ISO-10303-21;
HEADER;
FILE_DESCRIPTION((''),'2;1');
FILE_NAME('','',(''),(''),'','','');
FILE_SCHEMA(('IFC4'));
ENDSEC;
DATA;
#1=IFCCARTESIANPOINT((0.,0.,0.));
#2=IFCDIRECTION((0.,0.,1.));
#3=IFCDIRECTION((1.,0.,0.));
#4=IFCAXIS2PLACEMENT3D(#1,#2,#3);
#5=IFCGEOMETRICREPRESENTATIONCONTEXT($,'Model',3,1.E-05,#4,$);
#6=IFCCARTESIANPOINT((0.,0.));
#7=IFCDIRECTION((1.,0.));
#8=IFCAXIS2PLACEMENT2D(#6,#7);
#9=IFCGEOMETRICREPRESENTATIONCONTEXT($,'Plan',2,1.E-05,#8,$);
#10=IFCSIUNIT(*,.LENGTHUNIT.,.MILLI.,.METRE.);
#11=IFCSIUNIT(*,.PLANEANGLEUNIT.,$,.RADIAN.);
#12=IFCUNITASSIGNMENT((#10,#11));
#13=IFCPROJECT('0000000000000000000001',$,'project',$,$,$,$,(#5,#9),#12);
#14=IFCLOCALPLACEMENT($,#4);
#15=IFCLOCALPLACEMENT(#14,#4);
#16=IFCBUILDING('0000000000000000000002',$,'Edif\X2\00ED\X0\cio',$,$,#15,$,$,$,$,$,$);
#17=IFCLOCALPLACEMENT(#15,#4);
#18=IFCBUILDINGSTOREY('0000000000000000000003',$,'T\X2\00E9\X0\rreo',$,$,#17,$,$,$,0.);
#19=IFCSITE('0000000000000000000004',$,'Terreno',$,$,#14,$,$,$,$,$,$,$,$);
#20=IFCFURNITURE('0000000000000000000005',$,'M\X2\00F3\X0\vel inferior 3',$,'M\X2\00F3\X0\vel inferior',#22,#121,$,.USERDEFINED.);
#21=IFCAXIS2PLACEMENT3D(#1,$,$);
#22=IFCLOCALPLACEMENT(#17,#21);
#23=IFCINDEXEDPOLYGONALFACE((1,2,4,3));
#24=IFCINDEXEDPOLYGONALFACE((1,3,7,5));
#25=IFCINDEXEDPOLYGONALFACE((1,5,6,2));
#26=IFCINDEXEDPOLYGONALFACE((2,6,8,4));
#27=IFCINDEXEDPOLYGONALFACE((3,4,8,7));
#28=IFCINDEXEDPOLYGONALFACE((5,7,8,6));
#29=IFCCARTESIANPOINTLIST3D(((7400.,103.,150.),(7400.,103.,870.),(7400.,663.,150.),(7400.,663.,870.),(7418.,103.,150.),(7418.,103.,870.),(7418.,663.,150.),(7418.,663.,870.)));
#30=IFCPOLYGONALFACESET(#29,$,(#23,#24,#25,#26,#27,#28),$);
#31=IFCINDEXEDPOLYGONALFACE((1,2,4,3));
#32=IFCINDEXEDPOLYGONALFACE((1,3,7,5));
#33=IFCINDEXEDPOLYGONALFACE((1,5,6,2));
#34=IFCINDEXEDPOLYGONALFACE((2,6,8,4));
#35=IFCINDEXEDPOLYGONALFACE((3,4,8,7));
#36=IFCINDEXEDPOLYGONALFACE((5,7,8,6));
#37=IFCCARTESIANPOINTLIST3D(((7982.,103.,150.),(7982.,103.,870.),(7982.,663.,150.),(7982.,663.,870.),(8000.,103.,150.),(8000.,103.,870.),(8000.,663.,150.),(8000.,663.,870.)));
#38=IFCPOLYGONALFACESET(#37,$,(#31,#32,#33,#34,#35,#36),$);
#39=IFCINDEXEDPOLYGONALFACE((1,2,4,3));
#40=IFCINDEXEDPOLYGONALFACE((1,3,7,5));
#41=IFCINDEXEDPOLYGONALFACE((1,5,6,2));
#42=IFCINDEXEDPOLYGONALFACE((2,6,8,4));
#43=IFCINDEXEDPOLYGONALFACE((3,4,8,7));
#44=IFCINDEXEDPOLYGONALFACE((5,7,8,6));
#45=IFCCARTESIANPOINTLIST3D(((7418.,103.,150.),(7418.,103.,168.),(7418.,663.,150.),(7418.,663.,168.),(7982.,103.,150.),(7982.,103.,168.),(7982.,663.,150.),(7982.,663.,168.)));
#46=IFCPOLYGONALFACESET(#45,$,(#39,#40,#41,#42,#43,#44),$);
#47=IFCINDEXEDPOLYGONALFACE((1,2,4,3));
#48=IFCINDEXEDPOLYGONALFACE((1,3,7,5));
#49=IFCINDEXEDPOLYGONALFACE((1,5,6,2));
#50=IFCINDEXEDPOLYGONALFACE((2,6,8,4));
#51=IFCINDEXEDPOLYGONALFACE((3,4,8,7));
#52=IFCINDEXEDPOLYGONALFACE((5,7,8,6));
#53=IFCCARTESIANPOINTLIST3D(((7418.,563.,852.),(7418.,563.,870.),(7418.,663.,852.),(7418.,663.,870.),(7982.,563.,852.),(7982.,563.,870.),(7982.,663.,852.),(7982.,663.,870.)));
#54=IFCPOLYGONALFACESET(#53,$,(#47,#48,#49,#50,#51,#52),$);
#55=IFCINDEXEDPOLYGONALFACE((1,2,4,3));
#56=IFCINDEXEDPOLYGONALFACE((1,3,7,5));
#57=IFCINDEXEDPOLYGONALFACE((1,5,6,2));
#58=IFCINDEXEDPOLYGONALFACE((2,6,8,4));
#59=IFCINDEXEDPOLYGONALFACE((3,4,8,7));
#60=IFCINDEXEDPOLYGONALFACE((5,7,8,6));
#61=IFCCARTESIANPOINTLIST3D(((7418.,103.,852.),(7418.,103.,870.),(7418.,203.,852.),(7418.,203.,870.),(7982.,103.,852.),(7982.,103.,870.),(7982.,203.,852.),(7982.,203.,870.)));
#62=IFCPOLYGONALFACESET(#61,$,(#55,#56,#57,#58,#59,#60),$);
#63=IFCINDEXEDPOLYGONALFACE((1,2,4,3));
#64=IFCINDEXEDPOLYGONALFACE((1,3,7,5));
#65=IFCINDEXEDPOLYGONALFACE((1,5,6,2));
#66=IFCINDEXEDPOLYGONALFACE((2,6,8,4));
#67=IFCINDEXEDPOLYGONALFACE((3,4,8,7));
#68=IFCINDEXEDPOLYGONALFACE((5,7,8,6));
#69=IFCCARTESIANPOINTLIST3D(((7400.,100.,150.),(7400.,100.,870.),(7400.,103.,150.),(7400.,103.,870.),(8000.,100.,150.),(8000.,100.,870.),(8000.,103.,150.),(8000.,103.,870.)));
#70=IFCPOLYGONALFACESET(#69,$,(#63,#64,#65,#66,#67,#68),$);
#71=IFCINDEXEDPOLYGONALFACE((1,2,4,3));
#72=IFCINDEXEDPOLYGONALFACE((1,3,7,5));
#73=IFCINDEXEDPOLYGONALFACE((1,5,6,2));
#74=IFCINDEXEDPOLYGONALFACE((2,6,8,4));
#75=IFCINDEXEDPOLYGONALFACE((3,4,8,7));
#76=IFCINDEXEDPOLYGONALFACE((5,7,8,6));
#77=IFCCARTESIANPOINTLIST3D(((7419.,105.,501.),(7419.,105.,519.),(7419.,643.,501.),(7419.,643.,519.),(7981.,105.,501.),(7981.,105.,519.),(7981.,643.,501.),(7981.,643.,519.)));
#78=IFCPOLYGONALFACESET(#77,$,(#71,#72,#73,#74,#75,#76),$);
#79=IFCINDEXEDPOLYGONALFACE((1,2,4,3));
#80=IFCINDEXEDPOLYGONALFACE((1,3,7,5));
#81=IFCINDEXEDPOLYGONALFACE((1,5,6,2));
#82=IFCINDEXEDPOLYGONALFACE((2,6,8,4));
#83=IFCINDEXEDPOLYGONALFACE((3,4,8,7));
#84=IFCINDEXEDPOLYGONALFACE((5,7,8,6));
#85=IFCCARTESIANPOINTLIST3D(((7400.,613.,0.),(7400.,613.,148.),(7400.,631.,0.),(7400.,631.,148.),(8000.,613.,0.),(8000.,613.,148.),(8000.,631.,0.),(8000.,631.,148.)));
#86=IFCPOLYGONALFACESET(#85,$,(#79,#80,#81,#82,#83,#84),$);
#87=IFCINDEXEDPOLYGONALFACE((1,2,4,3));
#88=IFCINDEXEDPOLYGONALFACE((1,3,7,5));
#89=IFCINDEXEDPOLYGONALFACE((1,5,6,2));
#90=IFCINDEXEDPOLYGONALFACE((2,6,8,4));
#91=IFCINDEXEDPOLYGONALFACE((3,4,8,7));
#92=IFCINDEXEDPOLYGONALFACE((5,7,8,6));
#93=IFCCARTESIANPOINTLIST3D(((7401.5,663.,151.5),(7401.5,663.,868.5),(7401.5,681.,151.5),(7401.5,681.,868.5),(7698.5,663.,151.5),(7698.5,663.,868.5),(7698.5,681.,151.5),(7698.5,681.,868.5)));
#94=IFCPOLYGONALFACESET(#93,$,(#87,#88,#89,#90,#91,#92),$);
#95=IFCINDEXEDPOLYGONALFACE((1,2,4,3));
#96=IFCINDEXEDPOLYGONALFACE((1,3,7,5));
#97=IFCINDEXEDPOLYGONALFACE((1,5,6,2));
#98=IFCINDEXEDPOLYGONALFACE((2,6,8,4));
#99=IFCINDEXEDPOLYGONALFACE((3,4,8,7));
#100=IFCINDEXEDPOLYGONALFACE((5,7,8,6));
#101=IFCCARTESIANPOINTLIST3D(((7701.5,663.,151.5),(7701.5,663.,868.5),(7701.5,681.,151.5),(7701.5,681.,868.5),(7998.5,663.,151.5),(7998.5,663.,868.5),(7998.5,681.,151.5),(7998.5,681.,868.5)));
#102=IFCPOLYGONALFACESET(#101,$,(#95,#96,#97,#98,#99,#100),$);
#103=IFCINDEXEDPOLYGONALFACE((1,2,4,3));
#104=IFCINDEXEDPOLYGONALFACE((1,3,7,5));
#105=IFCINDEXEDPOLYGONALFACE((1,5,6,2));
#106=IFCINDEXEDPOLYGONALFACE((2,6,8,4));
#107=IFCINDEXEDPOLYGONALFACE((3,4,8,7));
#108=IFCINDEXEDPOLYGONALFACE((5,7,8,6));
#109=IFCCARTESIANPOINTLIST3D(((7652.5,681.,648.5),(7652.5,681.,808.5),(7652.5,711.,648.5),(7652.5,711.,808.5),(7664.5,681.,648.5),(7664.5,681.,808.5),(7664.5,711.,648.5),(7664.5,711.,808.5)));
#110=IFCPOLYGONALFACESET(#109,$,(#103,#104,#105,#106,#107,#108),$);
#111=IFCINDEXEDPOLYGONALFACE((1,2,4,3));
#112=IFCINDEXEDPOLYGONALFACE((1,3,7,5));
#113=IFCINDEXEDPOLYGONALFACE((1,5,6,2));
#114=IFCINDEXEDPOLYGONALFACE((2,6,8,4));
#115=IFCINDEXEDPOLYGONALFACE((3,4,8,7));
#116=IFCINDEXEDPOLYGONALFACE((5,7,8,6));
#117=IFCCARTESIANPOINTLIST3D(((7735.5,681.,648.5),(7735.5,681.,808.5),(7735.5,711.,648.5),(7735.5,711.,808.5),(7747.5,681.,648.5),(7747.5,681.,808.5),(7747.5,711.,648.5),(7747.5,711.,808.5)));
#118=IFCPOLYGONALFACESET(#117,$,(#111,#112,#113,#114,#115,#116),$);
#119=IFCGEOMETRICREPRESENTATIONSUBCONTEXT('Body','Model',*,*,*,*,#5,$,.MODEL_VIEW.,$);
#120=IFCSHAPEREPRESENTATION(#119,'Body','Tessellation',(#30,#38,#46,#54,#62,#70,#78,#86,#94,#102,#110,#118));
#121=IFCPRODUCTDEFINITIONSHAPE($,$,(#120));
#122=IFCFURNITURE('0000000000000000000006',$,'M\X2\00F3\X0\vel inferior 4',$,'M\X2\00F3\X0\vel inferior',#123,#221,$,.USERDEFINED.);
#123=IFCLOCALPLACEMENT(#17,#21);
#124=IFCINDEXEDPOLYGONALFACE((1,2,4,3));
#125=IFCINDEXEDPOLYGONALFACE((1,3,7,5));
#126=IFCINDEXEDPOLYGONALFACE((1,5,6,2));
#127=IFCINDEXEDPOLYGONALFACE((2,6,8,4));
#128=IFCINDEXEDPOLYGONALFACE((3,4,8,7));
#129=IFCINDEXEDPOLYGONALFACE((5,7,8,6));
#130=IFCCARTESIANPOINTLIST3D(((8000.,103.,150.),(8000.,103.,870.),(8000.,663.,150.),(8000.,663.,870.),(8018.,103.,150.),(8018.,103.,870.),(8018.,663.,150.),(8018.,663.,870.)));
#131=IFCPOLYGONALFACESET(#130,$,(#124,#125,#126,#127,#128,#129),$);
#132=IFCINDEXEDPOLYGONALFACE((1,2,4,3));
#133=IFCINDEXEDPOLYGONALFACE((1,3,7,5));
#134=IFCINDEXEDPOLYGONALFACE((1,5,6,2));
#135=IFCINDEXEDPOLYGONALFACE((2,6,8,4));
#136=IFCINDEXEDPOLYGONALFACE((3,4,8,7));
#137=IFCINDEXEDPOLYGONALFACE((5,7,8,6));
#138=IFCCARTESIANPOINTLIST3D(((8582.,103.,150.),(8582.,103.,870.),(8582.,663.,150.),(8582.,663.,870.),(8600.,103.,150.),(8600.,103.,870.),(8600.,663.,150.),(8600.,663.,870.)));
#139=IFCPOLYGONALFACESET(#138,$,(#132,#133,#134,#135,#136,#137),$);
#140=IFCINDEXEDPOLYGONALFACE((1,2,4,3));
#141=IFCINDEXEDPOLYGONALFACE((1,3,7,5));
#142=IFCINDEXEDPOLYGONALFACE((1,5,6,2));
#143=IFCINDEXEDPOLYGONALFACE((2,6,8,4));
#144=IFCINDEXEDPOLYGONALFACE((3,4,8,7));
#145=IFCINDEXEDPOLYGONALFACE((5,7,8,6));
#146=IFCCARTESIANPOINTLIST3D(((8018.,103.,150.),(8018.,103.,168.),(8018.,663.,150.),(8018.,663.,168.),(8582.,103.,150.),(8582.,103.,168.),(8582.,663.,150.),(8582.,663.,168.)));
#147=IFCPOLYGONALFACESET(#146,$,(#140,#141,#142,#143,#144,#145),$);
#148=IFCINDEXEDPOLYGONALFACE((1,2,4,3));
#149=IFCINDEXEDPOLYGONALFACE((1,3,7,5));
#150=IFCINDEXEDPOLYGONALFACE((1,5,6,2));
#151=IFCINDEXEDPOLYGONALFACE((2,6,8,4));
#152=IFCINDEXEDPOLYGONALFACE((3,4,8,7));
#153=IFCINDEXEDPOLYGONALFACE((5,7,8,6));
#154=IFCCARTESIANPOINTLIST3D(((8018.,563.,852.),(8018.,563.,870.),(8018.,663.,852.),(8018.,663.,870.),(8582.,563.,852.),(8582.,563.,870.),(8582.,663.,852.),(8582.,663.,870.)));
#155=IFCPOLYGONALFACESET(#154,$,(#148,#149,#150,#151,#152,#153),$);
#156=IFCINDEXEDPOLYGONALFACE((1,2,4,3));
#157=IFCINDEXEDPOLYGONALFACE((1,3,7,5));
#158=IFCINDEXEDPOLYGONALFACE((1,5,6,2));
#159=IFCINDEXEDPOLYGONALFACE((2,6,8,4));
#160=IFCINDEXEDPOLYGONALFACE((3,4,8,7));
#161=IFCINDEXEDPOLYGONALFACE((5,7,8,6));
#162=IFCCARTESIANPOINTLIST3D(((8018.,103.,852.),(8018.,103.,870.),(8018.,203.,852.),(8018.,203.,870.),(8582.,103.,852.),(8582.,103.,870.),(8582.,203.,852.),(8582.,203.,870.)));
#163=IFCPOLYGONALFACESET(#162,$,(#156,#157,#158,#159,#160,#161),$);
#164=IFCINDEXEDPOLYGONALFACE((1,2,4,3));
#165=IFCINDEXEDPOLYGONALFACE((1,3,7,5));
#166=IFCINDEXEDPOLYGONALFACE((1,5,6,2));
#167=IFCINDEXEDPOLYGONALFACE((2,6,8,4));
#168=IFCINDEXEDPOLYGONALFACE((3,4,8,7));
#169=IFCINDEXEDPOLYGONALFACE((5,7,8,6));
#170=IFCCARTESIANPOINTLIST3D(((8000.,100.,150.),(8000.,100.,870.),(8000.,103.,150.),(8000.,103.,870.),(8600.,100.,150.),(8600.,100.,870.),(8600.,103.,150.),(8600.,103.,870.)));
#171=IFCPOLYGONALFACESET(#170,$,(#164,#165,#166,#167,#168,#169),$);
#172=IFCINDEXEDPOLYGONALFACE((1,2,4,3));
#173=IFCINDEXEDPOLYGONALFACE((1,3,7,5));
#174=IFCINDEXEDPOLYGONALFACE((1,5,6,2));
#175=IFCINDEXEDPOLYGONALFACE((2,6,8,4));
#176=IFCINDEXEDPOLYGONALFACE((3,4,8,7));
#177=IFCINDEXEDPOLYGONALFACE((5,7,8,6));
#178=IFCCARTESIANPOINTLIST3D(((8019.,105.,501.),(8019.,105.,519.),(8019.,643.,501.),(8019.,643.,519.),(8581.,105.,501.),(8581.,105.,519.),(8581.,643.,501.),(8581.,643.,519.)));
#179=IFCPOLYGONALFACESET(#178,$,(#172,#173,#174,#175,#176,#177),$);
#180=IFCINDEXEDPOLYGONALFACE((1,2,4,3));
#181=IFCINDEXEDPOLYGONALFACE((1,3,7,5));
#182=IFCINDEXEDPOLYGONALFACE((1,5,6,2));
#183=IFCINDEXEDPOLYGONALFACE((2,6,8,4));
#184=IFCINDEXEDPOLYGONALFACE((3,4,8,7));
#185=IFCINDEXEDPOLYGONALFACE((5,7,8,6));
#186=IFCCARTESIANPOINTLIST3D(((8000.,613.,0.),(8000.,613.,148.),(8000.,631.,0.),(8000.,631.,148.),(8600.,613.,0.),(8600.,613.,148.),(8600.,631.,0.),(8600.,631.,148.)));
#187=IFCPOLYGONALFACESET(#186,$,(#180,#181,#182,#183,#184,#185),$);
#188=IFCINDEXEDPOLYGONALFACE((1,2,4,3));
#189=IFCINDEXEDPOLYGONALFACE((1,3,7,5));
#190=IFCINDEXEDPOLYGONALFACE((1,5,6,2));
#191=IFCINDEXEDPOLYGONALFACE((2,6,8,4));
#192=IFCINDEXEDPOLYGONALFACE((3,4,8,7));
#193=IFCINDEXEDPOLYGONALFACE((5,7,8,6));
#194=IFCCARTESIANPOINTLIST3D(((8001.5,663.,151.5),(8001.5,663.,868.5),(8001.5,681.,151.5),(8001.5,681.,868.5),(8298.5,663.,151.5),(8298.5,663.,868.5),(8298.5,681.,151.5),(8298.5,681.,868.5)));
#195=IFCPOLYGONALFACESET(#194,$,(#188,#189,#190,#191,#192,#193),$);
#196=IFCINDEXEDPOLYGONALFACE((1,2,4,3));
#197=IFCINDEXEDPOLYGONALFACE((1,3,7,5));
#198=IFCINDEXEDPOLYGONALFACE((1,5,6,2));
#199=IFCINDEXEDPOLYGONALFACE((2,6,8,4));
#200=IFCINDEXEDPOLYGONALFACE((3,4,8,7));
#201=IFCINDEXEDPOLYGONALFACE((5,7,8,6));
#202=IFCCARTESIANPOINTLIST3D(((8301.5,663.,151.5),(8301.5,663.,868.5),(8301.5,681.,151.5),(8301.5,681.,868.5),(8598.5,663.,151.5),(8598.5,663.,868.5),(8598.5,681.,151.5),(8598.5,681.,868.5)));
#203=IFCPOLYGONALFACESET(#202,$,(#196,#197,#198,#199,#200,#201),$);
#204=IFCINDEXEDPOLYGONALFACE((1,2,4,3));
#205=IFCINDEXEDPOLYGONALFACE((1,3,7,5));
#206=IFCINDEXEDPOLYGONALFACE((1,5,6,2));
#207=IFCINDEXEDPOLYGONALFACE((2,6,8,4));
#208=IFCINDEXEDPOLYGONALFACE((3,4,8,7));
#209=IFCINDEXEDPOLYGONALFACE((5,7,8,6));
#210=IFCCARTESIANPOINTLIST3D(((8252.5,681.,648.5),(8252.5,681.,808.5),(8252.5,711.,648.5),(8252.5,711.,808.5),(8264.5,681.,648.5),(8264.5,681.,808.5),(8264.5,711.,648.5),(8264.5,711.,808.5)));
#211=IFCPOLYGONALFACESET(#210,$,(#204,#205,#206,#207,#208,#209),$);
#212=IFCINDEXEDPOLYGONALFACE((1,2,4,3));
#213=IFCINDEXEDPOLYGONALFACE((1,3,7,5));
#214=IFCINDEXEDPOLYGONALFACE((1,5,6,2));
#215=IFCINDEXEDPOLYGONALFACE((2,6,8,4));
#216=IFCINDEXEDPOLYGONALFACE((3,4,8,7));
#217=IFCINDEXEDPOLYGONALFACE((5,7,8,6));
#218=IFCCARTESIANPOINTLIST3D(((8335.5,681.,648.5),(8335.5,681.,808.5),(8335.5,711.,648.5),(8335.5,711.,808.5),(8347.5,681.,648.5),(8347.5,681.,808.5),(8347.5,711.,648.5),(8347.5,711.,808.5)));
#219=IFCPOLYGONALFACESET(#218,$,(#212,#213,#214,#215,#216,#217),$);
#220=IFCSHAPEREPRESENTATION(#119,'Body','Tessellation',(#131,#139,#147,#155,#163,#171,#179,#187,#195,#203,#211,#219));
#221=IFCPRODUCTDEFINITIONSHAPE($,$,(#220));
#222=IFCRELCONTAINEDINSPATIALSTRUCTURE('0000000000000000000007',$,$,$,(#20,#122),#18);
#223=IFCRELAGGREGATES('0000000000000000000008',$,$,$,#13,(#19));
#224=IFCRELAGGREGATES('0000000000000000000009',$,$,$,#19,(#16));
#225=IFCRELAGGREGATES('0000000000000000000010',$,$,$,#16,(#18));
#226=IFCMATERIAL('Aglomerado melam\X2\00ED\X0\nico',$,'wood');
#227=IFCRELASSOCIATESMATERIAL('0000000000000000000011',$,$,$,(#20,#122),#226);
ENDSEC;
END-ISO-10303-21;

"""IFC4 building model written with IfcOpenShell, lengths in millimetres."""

from ifc_helpers import new_model, si_unit, frame, frame_2d, origin, origin_with_axes, origin_2d_with_axis, place, context, subcontext, project, spatial, rectangle, extrude, material, element, save


model = new_model("IFC4")

# Units and contexts
model_context = context("Model", 3, precision=1e-05, world=origin_with_axes())
plan_context = context("Plan", 2, precision=1e-05, world=origin_2d_with_axis())
body_context = subcontext(model_context, "Body", "Model", "MODEL_VIEW")
ifc_project = project(units=[si_unit("LENGTHUNIT", "METRE", prefix="MILLI"), si_unit("PLANEANGLEUNIT", "RADIAN")], contexts=[model_context, plan_context])

# Site, building, storey
site_placement = place(None, origin_with_axes())
site = spatial("IfcSite", under=ifc_project, at=site_placement, Name="Terreno")
building_placement = place(site_placement, origin_with_axes())
building = spatial("IfcBuilding", under=site, at=building_placement, Name="Edifício")
storey_placement = place(building_placement, origin_with_axes())
storey = spatial("IfcBuildingStorey", under=building, at=storey_placement, Name="Térreo", Elevation=0.0)

# Furniture
ifc_material_1 = material(Name="Aglomerado melamínico", Category="wood")
furniture_1_placement = place(storey_placement, frame((7400.0, 100.0, 0.0), z_axis=(0.0, 0.0, 1.0), x_axis=(1.0, 0.0, 0.0)))
element("IfcFurniture", 1, at=furniture_1_placement, inside=storey, material=ifc_material_1, Name="Móvel inferior 3", ObjectType="Móvel inferior", PredefinedType="USERDEFINED", context=body_context, shape_type="SweptSolid", body=[
    extrude(rectangle(XDim=18.0, YDim=560.0, at=frame_2d((9.0, 283.0))), frame((0.0, 0.0, 150.0)), (0.0, 0.0, 1.0), 720.0),
    extrude(rectangle(XDim=18.0, YDim=560.0, at=frame_2d((591.0, 283.0))), frame((0.0, 0.0, 150.0)), (0.0, 0.0, 1.0), 720.0),
    extrude(rectangle(XDim=564.0, YDim=560.0, at=frame_2d((300.0, 283.0))), frame((0.0, 0.0, 150.0)), (0.0, 0.0, 1.0), 18.0),
    extrude(rectangle(XDim=564.0, YDim=100.0, at=frame_2d((300.0, 513.0))), frame((0.0, 0.0, 852.0)), (0.0, 0.0, 1.0), 18.0),
    extrude(rectangle(XDim=564.0, YDim=100.0, at=frame_2d((300.0, 53.0))), frame((0.0, 0.0, 852.0)), (0.0, 0.0, 1.0), 18.0),
    extrude(rectangle(XDim=600.0, YDim=3.0, at=frame_2d((300.0, 1.5))), frame((0.0, 0.0, 150.0)), (0.0, 0.0, 1.0), 720.0),
    extrude(rectangle(XDim=562.0, YDim=538.0, at=frame_2d((300.0, 274.0))), frame((0.0, 0.0, 501.0)), (0.0, 0.0, 1.0), 18.0),
    extrude(rectangle(XDim=600.0, YDim=18.0, at=frame_2d((300.0, 522.0))), origin(), (0.0, 0.0, 1.0), 148.0),
    extrude(rectangle(XDim=297.0, YDim=18.0, at=frame_2d((150.0, 572.0))), frame((0.0, 0.0, 151.5)), (0.0, 0.0, 1.0), 717.0),
    extrude(rectangle(XDim=297.0, YDim=18.0, at=frame_2d((450.0, 572.0))), frame((0.0, 0.0, 151.5)), (0.0, 0.0, 1.0), 717.0),
    extrude(rectangle(XDim=12.0, YDim=30.0, at=frame_2d((258.5, 596.0))), frame((0.0, 0.0, 648.5)), (0.0, 0.0, 1.0), 160.0),
    extrude(rectangle(XDim=12.0, YDim=30.0, at=frame_2d((341.5, 596.0))), frame((0.0, 0.0, 648.5)), (0.0, 0.0, 1.0), 160.0),
])
furniture_2_placement = place(storey_placement, frame((8000.0, 100.0, 0.0), z_axis=(0.0, 0.0, 1.0), x_axis=(1.0, 0.0, 0.0)))
element("IfcFurniture", 2, at=furniture_2_placement, inside=storey, material=ifc_material_1, Name="Móvel inferior 4", ObjectType="Móvel inferior", PredefinedType="USERDEFINED", context=body_context, shape_type="SweptSolid", body=[
    extrude(rectangle(XDim=18.0, YDim=560.0, at=frame_2d((9.0, 283.0))), frame((0.0, 0.0, 150.0)), (0.0, 0.0, 1.0), 720.0),
    extrude(rectangle(XDim=18.0, YDim=560.0, at=frame_2d((591.0, 283.0))), frame((0.0, 0.0, 150.0)), (0.0, 0.0, 1.0), 720.0),
    extrude(rectangle(XDim=564.0, YDim=560.0, at=frame_2d((300.0, 283.0))), frame((0.0, 0.0, 150.0)), (0.0, 0.0, 1.0), 18.0),
    extrude(rectangle(XDim=564.0, YDim=100.0, at=frame_2d((300.0, 513.0))), frame((0.0, 0.0, 852.0)), (0.0, 0.0, 1.0), 18.0),
    extrude(rectangle(XDim=564.0, YDim=100.0, at=frame_2d((300.0, 53.0))), frame((0.0, 0.0, 852.0)), (0.0, 0.0, 1.0), 18.0),
    extrude(rectangle(XDim=600.0, YDim=3.0, at=frame_2d((300.0, 1.5))), frame((0.0, 0.0, 150.0)), (0.0, 0.0, 1.0), 720.0),
    extrude(rectangle(XDim=562.0, YDim=538.0, at=frame_2d((300.0, 274.0))), frame((0.0, 0.0, 501.0)), (0.0, 0.0, 1.0), 18.0),
    extrude(rectangle(XDim=600.0, YDim=18.0, at=frame_2d((300.0, 522.0))), origin(), (0.0, 0.0, 1.0), 148.0),
    extrude(rectangle(XDim=297.0, YDim=18.0, at=frame_2d((150.0, 572.0))), frame((0.0, 0.0, 151.5)), (0.0, 0.0, 1.0), 717.0),
    extrude(rectangle(XDim=297.0, YDim=18.0, at=frame_2d((450.0, 572.0))), frame((0.0, 0.0, 151.5)), (0.0, 0.0, 1.0), 717.0),
    extrude(rectangle(XDim=12.0, YDim=30.0, at=frame_2d((258.5, 596.0))), frame((0.0, 0.0, 648.5)), (0.0, 0.0, 1.0), 160.0),
    extrude(rectangle(XDim=12.0, YDim=30.0, at=frame_2d((341.5, 596.0))), frame((0.0, 0.0, 648.5)), (0.0, 0.0, 1.0), 160.0),
])

save(model, "model.ifc")
